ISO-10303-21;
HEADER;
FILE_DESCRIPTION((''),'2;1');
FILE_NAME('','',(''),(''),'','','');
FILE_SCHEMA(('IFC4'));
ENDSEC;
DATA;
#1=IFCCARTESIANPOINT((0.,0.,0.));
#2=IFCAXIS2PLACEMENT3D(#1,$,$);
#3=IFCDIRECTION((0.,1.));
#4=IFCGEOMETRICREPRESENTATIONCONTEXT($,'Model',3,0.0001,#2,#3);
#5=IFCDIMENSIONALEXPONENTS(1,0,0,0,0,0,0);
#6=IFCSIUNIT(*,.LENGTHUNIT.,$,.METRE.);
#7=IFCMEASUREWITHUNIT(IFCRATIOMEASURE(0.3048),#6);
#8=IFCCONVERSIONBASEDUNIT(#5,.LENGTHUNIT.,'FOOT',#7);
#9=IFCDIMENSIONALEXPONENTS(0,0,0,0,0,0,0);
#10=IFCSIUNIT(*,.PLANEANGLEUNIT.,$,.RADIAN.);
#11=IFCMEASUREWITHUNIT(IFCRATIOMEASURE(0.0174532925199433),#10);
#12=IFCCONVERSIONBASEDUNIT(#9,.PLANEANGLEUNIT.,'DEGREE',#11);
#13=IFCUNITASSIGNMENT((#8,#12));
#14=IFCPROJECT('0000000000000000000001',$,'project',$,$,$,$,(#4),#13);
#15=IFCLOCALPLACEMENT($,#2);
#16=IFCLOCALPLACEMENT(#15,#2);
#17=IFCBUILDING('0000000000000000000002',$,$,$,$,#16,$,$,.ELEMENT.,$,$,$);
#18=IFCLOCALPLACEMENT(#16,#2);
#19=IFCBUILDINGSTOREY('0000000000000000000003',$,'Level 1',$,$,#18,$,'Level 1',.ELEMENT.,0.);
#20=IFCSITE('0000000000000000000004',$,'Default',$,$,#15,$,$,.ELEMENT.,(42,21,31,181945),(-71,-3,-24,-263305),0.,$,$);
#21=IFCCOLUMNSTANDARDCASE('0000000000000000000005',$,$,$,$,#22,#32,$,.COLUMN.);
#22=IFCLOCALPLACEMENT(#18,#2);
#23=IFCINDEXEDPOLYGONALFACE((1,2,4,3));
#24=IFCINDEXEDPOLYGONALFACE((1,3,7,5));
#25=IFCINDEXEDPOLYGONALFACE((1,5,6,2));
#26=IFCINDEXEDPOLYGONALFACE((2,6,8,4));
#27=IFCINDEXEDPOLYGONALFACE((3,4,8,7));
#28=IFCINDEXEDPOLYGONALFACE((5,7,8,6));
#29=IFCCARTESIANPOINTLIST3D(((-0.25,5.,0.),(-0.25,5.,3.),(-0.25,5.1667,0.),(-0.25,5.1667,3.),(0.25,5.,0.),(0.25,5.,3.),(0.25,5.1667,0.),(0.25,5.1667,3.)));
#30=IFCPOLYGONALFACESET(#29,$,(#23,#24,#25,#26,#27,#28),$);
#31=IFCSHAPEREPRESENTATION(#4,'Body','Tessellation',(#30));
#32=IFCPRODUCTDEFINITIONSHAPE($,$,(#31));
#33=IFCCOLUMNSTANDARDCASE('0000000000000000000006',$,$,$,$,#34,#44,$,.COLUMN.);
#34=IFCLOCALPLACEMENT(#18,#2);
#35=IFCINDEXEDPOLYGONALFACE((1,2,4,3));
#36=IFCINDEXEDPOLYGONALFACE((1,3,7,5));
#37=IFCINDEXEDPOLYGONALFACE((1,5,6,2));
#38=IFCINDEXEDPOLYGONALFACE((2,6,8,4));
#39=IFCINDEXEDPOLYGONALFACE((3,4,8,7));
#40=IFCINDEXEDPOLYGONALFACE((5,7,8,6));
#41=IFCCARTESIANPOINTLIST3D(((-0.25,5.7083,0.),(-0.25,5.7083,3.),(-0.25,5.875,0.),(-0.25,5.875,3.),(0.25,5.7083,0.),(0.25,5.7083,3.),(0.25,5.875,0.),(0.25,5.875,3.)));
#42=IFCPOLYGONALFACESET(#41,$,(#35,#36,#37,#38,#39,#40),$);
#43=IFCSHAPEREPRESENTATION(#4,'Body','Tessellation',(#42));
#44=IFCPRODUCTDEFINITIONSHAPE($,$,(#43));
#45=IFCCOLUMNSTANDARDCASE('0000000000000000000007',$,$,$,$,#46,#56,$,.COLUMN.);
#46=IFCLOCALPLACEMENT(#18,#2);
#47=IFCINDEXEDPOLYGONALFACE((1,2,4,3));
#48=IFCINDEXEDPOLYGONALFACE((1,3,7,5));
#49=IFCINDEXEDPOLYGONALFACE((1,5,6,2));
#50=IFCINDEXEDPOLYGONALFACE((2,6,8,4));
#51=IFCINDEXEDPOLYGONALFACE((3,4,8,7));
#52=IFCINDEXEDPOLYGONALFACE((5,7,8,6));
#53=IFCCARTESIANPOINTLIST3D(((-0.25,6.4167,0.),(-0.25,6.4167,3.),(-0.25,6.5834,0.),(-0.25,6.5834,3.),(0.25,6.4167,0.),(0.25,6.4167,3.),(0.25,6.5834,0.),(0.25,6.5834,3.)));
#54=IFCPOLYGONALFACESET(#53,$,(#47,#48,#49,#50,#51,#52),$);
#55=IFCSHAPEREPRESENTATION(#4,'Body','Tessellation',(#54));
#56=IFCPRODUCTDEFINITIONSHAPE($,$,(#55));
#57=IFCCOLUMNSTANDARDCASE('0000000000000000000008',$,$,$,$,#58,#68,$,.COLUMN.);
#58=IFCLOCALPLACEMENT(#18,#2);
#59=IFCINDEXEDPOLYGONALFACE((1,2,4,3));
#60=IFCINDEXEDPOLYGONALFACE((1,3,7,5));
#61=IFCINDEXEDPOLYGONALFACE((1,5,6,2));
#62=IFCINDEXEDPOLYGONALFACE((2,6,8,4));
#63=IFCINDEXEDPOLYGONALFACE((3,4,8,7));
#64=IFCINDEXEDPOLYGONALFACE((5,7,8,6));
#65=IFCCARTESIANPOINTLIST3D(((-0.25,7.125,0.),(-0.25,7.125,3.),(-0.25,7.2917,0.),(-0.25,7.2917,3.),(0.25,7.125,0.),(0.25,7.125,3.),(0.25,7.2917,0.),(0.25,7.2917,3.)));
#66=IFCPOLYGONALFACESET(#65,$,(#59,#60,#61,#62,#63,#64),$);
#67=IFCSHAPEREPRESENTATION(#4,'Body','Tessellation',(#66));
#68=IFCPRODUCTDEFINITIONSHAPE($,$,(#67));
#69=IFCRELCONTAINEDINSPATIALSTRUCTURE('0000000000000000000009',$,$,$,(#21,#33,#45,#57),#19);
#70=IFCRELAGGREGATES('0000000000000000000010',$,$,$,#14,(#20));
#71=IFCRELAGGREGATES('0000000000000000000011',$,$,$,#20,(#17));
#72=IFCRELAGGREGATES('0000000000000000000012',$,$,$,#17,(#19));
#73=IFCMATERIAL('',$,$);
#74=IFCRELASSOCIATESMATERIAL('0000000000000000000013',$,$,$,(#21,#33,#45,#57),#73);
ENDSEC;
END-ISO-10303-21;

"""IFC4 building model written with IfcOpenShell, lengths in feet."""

from ifc_helpers import new_model, entity, si_unit, converted_unit, direction, frame, origin, place, context, project, spatial, rectangle, extrude, material, element, save


model = new_model("IFC4")

# Units and contexts
model_context = context("Model", 3, precision=0.0001, world=origin(), true_north=direction((0.0, 1.0)))
ifc_project = project(units=[converted_unit("LENGTHUNIT", "FOOT", entity("IfcRatioMeasure", 0.3048), si_unit("LENGTHUNIT", "METRE"), dimensions=[1, 0, 0, 0, 0, 0, 0]), converted_unit("PLANEANGLEUNIT", "DEGREE", entity("IfcRatioMeasure", 0.0174532925199433), si_unit("PLANEANGLEUNIT", "RADIAN"), dimensions=[0, 0, 0, 0, 0, 0, 0])], contexts=[model_context])

# Site, building, storey
site_placement = place(None, origin())
site = spatial("IfcSite", under=ifc_project, at=site_placement, Name="Default", CompositionType="ELEMENT", RefLatitude=(42, 21, 31, 181945), RefLongitude=(-71, -3, -24, -263305), RefElevation=0.0)
building_placement = place(site_placement, origin())
building = spatial("IfcBuilding", under=site, at=building_placement, CompositionType="ELEMENT")
storey_placement = place(building_placement, origin())
storey = spatial("IfcBuildingStorey", under=building, at=storey_placement, Name="Level 1", LongName="Level 1", CompositionType="ELEMENT", Elevation=0.0)

# Columns
placement_1 = place(storey_placement, frame((0.0, -0.25, 0.0), z_axis=(0.0, 0.0, 1.0), x_axis=(0.0, 1.0, 0.0)))
ifc_material_1 = material(Name="")
for number, where, z_axis, x_axis in (
    (1, (5.3334, 0.0, 0.0), (0.0, 0.0, 1.0), (1.0, 0.0, 0.0)),
    (2, (6.0417, 0.0, 0.0), (0.0, 0.0, 1.0), (1.0, 0.0, 0.0)),
    (3, (6.75, 0.0, 0.0), (0.0, 0.0, 1.0), (1.0, 0.0, 0.0)),
    (4, (7.4583, 0.0, 0.0), (0.0, 0.0, 1.0), (1.0, 0.0, 0.0)),
):
    element("IfcColumnStandardCase", number, at=place(placement_1, frame(where, z_axis=z_axis, x_axis=x_axis)), inside=storey, material=ifc_material_1, PredefinedType="COLUMN", context=model_context, shape_type="SweptSolid", body=[
        extrude(rectangle(XDim=0.1667, YDim=0.5), origin(), (0.0, 0.0, 1.0), 3.0),
    ])

save(model, "model.ifc")
